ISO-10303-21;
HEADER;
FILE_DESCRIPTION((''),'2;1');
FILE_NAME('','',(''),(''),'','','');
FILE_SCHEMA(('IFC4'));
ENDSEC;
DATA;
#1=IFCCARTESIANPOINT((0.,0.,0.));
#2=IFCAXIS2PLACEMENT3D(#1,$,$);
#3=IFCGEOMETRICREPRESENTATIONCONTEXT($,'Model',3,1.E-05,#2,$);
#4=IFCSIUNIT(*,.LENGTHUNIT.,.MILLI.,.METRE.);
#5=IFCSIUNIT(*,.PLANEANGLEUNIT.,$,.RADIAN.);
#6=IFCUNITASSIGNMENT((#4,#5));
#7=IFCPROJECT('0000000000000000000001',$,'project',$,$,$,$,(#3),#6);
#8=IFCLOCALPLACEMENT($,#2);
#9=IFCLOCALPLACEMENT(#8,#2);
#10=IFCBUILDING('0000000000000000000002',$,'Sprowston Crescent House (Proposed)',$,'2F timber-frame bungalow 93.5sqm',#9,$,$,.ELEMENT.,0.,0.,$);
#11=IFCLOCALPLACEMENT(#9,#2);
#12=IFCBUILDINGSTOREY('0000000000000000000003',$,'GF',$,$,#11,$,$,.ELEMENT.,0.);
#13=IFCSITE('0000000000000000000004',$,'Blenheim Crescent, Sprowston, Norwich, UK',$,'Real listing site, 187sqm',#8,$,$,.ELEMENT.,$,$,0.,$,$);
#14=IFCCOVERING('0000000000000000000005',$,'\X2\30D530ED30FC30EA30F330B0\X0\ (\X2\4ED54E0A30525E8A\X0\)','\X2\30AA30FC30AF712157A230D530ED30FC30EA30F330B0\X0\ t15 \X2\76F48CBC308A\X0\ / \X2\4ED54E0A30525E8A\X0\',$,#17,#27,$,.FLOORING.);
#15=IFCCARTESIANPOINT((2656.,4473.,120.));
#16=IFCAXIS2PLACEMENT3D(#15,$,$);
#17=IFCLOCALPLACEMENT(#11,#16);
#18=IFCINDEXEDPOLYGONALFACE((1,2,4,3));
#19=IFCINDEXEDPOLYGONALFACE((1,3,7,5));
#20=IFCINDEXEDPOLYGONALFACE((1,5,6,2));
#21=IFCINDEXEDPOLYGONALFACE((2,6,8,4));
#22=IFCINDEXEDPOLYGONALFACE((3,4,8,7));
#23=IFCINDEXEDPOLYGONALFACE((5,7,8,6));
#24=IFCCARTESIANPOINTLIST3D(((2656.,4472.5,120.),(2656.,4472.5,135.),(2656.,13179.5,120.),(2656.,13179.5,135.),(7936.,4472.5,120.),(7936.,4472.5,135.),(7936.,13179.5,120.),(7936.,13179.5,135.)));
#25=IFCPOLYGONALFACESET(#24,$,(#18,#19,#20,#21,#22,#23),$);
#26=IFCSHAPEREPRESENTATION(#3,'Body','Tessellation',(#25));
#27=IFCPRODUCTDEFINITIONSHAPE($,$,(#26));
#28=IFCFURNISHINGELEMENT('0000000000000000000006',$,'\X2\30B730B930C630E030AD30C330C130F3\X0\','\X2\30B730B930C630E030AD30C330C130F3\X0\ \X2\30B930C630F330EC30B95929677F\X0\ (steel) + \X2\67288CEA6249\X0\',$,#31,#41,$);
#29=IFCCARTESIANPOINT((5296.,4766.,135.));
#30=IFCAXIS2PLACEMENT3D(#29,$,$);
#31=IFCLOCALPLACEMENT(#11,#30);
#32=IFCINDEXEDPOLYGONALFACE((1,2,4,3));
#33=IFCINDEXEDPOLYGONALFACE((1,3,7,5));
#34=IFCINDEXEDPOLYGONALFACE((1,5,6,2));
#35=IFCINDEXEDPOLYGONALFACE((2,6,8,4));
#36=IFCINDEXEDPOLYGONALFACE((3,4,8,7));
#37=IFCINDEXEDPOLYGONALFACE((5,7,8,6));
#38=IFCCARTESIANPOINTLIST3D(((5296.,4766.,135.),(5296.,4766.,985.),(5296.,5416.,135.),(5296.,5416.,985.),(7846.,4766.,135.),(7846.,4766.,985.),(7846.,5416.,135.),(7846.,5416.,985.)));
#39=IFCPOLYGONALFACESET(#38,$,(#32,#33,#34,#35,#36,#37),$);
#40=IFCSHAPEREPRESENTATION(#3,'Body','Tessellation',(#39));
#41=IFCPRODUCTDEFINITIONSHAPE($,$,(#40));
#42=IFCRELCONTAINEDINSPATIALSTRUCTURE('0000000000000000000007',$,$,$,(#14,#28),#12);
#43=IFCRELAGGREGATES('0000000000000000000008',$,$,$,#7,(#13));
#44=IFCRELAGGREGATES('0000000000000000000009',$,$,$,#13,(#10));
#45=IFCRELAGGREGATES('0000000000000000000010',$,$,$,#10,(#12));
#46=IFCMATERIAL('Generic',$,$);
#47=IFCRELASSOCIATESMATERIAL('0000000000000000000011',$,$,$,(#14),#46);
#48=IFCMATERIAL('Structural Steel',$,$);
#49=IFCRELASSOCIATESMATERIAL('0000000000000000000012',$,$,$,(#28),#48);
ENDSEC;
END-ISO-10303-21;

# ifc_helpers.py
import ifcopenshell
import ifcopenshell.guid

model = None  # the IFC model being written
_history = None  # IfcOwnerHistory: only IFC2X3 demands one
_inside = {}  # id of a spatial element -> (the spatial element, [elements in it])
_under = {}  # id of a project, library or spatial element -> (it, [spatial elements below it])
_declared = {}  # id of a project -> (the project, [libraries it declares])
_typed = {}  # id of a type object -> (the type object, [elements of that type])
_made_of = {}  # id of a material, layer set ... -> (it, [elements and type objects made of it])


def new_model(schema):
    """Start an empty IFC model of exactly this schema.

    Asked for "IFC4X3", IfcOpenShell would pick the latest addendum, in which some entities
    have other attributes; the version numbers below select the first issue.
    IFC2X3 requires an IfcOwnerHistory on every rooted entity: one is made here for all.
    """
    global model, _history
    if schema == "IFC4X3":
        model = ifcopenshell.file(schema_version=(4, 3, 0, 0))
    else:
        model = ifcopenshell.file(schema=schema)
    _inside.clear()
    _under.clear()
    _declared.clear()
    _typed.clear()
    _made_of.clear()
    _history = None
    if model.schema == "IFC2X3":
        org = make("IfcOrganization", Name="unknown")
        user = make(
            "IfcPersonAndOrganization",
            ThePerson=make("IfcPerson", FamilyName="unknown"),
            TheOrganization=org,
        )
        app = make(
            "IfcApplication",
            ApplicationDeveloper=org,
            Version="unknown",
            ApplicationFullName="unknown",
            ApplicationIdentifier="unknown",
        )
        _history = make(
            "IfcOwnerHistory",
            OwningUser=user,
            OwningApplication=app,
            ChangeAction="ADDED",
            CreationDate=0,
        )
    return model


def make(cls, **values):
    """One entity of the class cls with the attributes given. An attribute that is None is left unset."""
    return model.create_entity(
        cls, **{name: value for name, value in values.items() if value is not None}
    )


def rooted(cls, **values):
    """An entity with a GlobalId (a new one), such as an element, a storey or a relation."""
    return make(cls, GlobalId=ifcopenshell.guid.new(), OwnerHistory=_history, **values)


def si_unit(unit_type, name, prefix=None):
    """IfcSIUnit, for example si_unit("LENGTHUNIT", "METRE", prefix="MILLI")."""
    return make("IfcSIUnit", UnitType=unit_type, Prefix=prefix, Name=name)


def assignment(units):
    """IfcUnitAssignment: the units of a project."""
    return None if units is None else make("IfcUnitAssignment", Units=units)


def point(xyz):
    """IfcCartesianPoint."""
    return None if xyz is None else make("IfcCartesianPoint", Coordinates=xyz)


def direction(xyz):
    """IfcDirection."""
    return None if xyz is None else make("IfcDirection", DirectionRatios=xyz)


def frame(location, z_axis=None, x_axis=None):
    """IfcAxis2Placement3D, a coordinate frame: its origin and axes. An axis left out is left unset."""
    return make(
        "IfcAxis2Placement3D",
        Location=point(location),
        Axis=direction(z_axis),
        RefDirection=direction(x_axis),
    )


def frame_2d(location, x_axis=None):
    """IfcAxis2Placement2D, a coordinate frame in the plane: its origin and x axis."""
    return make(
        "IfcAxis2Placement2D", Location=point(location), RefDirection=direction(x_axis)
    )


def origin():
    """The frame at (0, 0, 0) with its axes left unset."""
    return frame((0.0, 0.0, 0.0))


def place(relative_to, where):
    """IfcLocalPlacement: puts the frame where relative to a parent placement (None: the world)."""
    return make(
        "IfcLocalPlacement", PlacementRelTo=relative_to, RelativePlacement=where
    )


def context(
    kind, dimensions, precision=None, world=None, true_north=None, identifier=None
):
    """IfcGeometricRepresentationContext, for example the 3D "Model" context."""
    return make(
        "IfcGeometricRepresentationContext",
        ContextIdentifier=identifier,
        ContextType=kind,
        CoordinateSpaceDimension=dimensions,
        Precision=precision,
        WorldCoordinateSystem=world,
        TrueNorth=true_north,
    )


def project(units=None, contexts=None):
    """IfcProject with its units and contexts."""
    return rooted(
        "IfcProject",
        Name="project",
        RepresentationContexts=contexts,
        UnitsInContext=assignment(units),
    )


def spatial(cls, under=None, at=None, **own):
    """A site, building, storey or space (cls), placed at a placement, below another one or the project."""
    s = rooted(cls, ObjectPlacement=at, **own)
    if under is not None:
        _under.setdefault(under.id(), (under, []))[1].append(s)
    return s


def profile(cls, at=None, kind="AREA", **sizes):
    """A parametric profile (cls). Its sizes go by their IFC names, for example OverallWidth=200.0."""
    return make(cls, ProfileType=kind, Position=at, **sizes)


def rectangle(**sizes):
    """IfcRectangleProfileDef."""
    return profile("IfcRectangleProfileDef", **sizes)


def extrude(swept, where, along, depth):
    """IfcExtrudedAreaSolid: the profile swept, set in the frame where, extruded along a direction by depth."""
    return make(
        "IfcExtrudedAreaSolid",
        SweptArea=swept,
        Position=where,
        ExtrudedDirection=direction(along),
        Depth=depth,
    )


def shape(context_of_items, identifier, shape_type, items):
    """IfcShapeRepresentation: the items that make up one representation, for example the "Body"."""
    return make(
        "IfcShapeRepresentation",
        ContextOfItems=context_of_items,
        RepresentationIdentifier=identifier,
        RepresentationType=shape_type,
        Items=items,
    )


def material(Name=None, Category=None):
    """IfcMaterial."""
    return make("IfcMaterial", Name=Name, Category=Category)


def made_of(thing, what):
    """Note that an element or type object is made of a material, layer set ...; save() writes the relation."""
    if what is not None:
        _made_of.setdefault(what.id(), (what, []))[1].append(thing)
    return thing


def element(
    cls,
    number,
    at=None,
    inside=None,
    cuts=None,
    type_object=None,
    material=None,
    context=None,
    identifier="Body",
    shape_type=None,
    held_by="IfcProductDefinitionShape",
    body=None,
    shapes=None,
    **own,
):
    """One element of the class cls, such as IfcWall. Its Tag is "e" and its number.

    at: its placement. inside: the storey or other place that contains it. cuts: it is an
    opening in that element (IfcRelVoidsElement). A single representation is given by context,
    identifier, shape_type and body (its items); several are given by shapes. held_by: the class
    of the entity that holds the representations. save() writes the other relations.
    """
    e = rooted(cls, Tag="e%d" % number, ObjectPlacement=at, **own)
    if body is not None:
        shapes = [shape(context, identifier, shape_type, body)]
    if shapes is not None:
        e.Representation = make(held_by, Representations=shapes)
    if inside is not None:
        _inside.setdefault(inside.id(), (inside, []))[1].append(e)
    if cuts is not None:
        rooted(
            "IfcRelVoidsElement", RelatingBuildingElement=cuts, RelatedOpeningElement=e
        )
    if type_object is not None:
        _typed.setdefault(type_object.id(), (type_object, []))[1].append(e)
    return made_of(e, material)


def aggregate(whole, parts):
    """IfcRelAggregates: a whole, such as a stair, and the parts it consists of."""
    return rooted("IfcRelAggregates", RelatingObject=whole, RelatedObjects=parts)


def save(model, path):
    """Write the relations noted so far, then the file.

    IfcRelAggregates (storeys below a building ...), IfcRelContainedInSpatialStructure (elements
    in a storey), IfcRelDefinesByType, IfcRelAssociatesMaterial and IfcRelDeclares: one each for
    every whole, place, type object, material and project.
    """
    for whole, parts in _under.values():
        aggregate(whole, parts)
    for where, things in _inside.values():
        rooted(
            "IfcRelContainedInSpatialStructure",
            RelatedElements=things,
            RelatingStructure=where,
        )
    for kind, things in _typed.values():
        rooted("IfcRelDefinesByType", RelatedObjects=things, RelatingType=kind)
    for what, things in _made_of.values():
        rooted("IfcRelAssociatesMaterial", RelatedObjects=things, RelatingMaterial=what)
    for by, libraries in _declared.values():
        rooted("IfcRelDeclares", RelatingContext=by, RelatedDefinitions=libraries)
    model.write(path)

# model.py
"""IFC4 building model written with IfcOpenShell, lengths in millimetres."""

from ifc_helpers import new_model, si_unit, frame, frame_2d, origin, place, context, project, spatial, rectangle, extrude, material, element, save


model = new_model("IFC4")

# Units and contexts
model_context = context("Model", 3, precision=1e-05, world=origin())
ifc_project = project(units=[si_unit("LENGTHUNIT", "METRE", prefix="MILLI"), si_unit("PLANEANGLEUNIT", "RADIAN")], contexts=[model_context])

# Site, building, storey
site_placement = place(None, origin())
site = spatial("IfcSite", under=ifc_project, at=site_placement, Name="Blenheim Crescent, Sprowston, Norwich, UK", ObjectType="Real listing site, 187sqm", CompositionType="ELEMENT", RefElevation=0.0)
building_placement = place(site_placement, origin())
building = spatial("IfcBuilding", under=site, at=building_placement, Name="Sprowston Crescent House (Proposed)", ObjectType="2F timber-frame bungalow 93.5sqm", CompositionType="ELEMENT", ElevationOfRefHeight=0.0, ElevationOfTerrain=0.0)
storey_placement = place(building_placement, origin())
storey = spatial("IfcBuildingStorey", under=building, at=storey_placement, Name="GF", CompositionType="ELEMENT", Elevation=0.0)

# Covering
ifc_material_1 = material(Name="Generic")
covering_placement = place(storey_placement, frame((2656.0, 4473.0, 120.0)))
element("IfcCovering", 1, at=covering_placement, inside=storey, material=ifc_material_1, Name="フローリング (仕上げ床)", Description="オーク無垢フローリング t15 直貼り / 仕上げ床", PredefinedType="FLOORING", context=model_context, shape_type="SweptSolid", body=[
    extrude(rectangle(XDim=5280.0, YDim=8707.0, at=frame_2d((2640.0, 4353.0))), frame((2656.0, 4473.0, 120.0)), (0.0, 0.0, 1.0), 15.0),
])

# Furnishing element
ifc_material_2 = material(Name="Structural Steel")
furnishing_placement = place(storey_placement, frame((5296.0, 4766.0, 135.0)))
element("IfcFurnishingElement", 2, at=furnishing_placement, inside=storey, material=ifc_material_2, Name="システムキッチン", Description="システムキッチン ステンレス天板 (steel) + 木質扉", context=model_context, shape_type="SweptSolid", body=[
    extrude(rectangle(XDim=2550.0, YDim=650.0, at=frame_2d((1275.0, 325.0))), frame((5296.0, 4766.0, 135.0)), (0.0, 0.0, 1.0), 850.0),
])

save(model, "model.ifc")
